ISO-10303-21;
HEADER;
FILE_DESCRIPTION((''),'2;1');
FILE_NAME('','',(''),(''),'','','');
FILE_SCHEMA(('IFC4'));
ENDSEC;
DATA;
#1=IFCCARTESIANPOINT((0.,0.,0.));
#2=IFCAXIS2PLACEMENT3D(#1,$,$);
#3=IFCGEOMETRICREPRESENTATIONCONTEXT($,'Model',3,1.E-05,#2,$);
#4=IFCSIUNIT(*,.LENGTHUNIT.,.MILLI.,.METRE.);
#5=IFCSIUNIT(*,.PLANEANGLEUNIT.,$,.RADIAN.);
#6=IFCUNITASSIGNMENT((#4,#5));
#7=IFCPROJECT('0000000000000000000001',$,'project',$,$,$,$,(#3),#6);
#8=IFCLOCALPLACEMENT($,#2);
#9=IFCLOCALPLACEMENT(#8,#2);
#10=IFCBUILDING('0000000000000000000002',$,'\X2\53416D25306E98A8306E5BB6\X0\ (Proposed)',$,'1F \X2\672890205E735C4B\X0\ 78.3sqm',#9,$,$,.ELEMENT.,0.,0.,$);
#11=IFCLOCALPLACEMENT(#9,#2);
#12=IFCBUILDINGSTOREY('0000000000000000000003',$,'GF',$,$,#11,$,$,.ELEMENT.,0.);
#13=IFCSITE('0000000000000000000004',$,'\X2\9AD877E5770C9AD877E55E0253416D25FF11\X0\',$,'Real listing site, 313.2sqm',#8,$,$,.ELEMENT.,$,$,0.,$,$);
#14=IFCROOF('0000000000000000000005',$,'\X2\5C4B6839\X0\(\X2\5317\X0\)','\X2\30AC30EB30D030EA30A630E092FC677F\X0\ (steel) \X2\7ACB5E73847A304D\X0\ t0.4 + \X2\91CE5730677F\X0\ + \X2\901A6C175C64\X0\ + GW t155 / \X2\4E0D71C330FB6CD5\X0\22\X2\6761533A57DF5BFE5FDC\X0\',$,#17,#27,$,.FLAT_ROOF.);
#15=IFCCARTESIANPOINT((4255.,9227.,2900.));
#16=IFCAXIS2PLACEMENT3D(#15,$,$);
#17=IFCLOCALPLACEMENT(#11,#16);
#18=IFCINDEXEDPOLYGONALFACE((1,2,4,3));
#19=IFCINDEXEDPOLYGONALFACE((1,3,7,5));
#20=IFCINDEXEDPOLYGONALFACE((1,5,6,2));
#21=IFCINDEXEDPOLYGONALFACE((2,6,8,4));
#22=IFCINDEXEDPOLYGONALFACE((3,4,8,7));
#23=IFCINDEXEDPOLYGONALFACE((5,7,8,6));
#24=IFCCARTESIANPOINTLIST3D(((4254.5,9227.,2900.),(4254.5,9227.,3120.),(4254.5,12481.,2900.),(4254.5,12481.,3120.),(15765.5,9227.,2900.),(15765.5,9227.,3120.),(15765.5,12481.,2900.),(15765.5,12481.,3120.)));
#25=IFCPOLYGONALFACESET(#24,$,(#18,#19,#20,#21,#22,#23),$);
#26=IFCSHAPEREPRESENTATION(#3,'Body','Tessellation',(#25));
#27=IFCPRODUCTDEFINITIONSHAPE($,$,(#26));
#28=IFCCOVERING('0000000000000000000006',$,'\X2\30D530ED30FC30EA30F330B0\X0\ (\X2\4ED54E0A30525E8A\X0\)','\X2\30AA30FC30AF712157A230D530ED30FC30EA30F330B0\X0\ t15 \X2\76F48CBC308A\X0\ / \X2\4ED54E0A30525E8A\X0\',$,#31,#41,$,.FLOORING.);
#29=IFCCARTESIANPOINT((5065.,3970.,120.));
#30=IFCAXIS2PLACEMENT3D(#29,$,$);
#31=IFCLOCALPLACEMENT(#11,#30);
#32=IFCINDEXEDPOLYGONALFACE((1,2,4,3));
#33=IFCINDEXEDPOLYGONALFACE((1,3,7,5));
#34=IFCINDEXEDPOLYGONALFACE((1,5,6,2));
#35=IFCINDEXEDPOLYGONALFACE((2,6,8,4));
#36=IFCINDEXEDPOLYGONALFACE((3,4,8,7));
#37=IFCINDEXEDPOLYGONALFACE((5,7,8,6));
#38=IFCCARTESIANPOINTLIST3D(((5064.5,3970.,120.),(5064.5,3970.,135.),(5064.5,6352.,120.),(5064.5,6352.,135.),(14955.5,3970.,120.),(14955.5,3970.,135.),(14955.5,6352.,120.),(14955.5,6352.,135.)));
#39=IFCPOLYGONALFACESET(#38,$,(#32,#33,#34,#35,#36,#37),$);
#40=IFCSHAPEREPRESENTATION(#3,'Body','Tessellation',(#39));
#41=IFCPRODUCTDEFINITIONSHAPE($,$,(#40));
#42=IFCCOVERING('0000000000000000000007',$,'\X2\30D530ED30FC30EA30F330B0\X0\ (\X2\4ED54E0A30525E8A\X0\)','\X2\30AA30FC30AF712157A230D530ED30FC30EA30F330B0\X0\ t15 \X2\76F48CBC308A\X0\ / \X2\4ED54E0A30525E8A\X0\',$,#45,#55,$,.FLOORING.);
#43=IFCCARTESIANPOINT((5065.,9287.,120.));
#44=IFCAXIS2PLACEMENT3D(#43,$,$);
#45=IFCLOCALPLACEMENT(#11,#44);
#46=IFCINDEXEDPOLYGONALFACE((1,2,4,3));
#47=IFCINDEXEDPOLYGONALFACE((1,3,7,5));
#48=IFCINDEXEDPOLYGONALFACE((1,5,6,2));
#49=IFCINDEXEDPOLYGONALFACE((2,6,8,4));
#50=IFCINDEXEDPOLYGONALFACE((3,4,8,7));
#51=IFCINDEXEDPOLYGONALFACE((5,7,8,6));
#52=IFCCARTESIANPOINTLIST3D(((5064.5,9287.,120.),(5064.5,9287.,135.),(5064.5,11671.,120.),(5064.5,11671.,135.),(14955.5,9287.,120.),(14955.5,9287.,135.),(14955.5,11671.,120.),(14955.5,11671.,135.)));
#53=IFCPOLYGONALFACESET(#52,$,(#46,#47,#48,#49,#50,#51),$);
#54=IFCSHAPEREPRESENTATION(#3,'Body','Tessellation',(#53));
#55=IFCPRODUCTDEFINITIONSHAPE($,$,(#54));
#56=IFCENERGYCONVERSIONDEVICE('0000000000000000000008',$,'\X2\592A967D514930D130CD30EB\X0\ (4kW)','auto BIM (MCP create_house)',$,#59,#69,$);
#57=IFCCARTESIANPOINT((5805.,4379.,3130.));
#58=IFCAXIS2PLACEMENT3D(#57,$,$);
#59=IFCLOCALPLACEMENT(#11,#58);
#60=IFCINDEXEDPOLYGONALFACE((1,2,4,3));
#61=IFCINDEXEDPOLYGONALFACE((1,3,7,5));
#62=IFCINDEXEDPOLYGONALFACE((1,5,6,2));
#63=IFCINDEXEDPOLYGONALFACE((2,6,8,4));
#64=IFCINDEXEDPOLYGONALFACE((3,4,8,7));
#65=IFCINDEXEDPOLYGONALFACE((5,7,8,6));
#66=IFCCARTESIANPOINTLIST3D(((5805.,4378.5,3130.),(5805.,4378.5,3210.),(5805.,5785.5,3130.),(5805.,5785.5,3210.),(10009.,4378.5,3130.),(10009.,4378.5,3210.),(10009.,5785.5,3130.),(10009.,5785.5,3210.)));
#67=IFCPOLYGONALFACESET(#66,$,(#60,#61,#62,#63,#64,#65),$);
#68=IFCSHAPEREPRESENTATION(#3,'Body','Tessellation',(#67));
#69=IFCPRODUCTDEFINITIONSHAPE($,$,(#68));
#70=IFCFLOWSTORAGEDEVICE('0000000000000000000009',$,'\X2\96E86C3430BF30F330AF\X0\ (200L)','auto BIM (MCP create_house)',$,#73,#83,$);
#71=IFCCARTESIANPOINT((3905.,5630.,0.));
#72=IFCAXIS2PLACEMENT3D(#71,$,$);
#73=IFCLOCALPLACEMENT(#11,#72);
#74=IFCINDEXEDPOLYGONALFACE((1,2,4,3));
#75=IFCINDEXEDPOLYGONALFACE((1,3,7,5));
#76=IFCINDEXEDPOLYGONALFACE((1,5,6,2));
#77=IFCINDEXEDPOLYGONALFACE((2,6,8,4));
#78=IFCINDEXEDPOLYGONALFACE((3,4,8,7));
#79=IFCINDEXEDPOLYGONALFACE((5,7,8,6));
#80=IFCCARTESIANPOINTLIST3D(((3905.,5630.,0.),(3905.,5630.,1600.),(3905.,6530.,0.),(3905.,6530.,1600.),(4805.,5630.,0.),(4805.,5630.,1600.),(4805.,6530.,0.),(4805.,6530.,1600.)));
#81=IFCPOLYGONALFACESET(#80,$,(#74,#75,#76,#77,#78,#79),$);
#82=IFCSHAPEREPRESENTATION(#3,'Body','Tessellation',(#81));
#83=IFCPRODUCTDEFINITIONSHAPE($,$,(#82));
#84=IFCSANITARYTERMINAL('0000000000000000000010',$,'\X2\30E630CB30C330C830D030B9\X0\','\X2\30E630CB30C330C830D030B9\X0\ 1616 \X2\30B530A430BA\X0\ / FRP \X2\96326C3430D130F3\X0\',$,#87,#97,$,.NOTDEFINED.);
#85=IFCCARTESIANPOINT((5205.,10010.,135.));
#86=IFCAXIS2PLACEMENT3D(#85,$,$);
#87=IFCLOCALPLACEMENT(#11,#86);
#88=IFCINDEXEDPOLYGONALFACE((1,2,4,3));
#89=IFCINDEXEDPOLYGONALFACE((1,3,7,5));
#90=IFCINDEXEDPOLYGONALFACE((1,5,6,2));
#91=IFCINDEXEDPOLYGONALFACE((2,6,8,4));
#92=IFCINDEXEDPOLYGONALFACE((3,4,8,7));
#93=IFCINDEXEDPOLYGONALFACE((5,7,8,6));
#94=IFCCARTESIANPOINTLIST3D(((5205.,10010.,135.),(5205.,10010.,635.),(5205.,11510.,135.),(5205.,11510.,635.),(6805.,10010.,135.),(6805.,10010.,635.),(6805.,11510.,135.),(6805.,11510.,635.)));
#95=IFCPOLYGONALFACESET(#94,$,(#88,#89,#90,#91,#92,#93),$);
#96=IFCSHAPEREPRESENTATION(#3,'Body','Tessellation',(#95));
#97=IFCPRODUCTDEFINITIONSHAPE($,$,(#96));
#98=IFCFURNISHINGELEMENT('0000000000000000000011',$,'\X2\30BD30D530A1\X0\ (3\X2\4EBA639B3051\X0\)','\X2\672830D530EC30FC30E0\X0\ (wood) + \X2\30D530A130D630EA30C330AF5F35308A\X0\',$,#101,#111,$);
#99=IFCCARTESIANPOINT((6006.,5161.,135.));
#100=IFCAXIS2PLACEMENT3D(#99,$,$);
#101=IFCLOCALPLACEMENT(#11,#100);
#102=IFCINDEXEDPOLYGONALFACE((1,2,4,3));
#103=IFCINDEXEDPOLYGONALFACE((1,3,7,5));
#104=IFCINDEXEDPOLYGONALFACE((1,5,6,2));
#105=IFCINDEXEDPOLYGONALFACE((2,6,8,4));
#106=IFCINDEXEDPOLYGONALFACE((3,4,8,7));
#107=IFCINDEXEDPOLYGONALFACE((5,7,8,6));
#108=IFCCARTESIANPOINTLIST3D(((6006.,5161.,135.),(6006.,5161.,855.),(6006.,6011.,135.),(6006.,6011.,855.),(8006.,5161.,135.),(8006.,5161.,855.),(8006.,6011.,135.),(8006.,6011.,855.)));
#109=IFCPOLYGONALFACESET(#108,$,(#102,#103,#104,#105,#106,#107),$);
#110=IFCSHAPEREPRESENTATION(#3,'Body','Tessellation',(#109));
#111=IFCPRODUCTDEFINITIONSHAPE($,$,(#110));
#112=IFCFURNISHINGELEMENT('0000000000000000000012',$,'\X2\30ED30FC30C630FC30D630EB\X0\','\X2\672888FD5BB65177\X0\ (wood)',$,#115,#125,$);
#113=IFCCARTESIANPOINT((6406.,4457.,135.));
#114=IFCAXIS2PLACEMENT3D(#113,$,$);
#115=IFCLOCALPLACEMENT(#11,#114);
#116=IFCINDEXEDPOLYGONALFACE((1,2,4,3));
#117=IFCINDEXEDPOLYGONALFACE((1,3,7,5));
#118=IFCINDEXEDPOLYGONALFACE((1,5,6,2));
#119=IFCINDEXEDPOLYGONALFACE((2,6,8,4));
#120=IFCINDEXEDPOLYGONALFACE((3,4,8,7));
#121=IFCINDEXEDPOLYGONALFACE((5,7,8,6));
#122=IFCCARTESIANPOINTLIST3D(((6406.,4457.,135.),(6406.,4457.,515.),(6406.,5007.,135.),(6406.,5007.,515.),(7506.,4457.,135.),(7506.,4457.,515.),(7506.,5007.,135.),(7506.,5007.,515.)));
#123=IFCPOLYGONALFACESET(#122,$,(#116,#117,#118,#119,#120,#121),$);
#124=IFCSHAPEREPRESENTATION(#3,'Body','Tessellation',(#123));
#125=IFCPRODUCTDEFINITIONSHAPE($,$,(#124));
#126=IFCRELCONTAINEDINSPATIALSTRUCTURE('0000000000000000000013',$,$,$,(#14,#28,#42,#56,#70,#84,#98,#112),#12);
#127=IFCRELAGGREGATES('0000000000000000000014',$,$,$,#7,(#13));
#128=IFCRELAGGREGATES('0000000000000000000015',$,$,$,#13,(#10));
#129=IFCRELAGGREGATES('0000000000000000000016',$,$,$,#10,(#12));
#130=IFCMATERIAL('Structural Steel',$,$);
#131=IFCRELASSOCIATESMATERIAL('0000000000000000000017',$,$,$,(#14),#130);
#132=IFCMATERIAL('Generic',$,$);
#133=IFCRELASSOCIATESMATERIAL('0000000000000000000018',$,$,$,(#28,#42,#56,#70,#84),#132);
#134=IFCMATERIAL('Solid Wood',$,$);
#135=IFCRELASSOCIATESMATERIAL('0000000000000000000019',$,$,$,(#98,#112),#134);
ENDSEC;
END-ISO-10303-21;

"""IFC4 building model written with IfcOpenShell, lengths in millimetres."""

from ifc_helpers import new_model, si_unit, frame, frame_2d, origin, place, context, project, spatial, rectangle, extrude, material, element, save


model = new_model("IFC4")

# Units and contexts
model_context = context("Model", 3, precision=1e-05, world=origin())
ifc_project = project(units=[si_unit("LENGTHUNIT", "METRE", prefix="MILLI"), si_unit("PLANEANGLEUNIT", "RADIAN")], contexts=[model_context])

# Site, building, storey
site_placement = place(None, origin())
site = spatial("IfcSite", under=ifc_project, at=site_placement, Name="高知県高知市十津１", ObjectType="Real listing site, 313.2sqm", CompositionType="ELEMENT", RefElevation=0.0)
building_placement = place(site_placement, origin())
building = spatial("IfcBuilding", under=site, at=building_placement, Name="十津の風の家 (Proposed)", ObjectType="1F 木造平屋 78.3sqm", CompositionType="ELEMENT", ElevationOfRefHeight=0.0, ElevationOfTerrain=0.0)
storey_placement = place(building_placement, origin())
storey = spatial("IfcBuildingStorey", under=building, at=storey_placement, Name="GF", CompositionType="ELEMENT", Elevation=0.0)

# Shared definitions
ifc_material_1 = material(Name="Solid Wood")

# Roof
ifc_material_2 = material(Name="Structural Steel")
roof_1_placement = place(storey_placement, frame((4255.0, 9227.0, 2900.0)))
element("IfcRoof", 1, at=roof_1_placement, inside=storey, material=ifc_material_2, Name="屋根(北)", Description="ガルバリウム鋼板 (steel) 立平葺き t0.4 + 野地板 + 通気層 + GW t155 / 不燃・法22条区域対応", PredefinedType="FLAT_ROOF", context=model_context, shape_type="SweptSolid", body=[
    extrude(rectangle(XDim=11511.0, YDim=3254.0, at=frame_2d((5755.0, 1627.0))), frame((4255.0, 9227.0, 2900.0)), (0.0, 0.0, 1.0), 220.0),
])

# Coverings
ifc_material_3 = material(Name="Generic")
covering_1_placement = place(storey_placement, frame((5065.0, 3970.0, 120.0)))
element("IfcCovering", 2, at=covering_1_placement, inside=storey, material=ifc_material_3, Name="フローリング (仕上げ床)", Description="オーク無垢フローリング t15 直貼り / 仕上げ床", PredefinedType="FLOORING", context=model_context, shape_type="SweptSolid", body=[
    extrude(rectangle(XDim=9891.0, YDim=2382.0, at=frame_2d((4945.0, 1191.0))), frame((5065.0, 3970.0, 120.0)), (0.0, 0.0, 1.0), 15.0),
])
covering_2_placement = place(storey_placement, frame((5065.0, 9287.0, 120.0)))
element("IfcCovering", 3, at=covering_2_placement, inside=storey, material=ifc_material_3, Name="フローリング (仕上げ床)", Description="オーク無垢フローリング t15 直貼り / 仕上げ床", PredefinedType="FLOORING", context=model_context, shape_type="SweptSolid", body=[
    extrude(rectangle(XDim=9891.0, YDim=2384.0, at=frame_2d((4945.0, 1192.0))), frame((5065.0, 9287.0, 120.0)), (0.0, 0.0, 1.0), 15.0),
])

# Energy conversion device
energy_conversion_device_placement = place(storey_placement, frame((5805.0, 4379.0, 3130.0)))
element("IfcEnergyConversionDevice", 4, at=energy_conversion_device_placement, inside=storey, material=ifc_material_3, Name="太陽光パネル (4kW)", Description="auto BIM (MCP create_house)", context=model_context, shape_type="SweptSolid", body=[
    extrude(rectangle(XDim=4204.0, YDim=1407.0, at=frame_2d((2102.0, 703.0))), frame((5805.0, 4379.0, 3130.0)), (0.0, 0.0, 1.0), 80.0),
])

# Flow storage device
flow_storage_device_placement = place(storey_placement, frame((3905.0, 5630.0, 0.0)))
element("IfcFlowStorageDevice", 5, at=flow_storage_device_placement, inside=storey, material=ifc_material_3, Name="雨水タンク (200L)", Description="auto BIM (MCP create_house)", context=model_context, shape_type="SweptSolid", body=[
    extrude(rectangle(XDim=900.0, YDim=900.0, at=frame_2d((450.0, 450.0))), frame((3905.0, 5630.0, 0.0)), (0.0, 0.0, 1.0), 1600.0),
])

# Sanitary terminal
sanitary_terminal_placement = place(storey_placement, frame((5205.0, 10010.0, 135.0)))
element("IfcSanitaryTerminal", 6, at=sanitary_terminal_placement, inside=storey, material=ifc_material_3, Name="ユニットバス", Description="ユニットバス 1616 サイズ / FRP 防水パン", PredefinedType="NOTDEFINED", context=model_context, shape_type="SweptSolid", body=[
    extrude(rectangle(XDim=1600.0, YDim=1500.0, at=frame_2d((800.0, 750.0))), frame((5205.0, 10010.0, 135.0)), (0.0, 0.0, 1.0), 500.0),
])

# Furnishing elements
furnishing_1_placement = place(storey_placement, frame((6006.0, 5161.0, 135.0)))
element("IfcFurnishingElement", 7, at=furnishing_1_placement, inside=storey, material=ifc_material_1, Name="ソファ (3人掛け)", Description="木フレーム (wood) + ファブリック張り", context=model_context, shape_type="SweptSolid", body=[
    extrude(rectangle(XDim=2000.0, YDim=850.0, at=frame_2d((1000.0, 425.0))), frame((6006.0, 5161.0, 135.0)), (0.0, 0.0, 1.0), 720.0),
])
furnishing_2_placement = place(storey_placement, frame((6406.0, 4457.0, 135.0)))
element("IfcFurnishingElement", 8, at=furnishing_2_placement, inside=storey, material=ifc_material_1, Name="ローテーブル", Description="木製家具 (wood)", context=model_context, shape_type="SweptSolid", body=[
    extrude(rectangle(XDim=1100.0, YDim=550.0, at=frame_2d((550.0, 275.0))), frame((6406.0, 4457.0, 135.0)), (0.0, 0.0, 1.0), 380.0),
])

save(model, "model.ifc")
